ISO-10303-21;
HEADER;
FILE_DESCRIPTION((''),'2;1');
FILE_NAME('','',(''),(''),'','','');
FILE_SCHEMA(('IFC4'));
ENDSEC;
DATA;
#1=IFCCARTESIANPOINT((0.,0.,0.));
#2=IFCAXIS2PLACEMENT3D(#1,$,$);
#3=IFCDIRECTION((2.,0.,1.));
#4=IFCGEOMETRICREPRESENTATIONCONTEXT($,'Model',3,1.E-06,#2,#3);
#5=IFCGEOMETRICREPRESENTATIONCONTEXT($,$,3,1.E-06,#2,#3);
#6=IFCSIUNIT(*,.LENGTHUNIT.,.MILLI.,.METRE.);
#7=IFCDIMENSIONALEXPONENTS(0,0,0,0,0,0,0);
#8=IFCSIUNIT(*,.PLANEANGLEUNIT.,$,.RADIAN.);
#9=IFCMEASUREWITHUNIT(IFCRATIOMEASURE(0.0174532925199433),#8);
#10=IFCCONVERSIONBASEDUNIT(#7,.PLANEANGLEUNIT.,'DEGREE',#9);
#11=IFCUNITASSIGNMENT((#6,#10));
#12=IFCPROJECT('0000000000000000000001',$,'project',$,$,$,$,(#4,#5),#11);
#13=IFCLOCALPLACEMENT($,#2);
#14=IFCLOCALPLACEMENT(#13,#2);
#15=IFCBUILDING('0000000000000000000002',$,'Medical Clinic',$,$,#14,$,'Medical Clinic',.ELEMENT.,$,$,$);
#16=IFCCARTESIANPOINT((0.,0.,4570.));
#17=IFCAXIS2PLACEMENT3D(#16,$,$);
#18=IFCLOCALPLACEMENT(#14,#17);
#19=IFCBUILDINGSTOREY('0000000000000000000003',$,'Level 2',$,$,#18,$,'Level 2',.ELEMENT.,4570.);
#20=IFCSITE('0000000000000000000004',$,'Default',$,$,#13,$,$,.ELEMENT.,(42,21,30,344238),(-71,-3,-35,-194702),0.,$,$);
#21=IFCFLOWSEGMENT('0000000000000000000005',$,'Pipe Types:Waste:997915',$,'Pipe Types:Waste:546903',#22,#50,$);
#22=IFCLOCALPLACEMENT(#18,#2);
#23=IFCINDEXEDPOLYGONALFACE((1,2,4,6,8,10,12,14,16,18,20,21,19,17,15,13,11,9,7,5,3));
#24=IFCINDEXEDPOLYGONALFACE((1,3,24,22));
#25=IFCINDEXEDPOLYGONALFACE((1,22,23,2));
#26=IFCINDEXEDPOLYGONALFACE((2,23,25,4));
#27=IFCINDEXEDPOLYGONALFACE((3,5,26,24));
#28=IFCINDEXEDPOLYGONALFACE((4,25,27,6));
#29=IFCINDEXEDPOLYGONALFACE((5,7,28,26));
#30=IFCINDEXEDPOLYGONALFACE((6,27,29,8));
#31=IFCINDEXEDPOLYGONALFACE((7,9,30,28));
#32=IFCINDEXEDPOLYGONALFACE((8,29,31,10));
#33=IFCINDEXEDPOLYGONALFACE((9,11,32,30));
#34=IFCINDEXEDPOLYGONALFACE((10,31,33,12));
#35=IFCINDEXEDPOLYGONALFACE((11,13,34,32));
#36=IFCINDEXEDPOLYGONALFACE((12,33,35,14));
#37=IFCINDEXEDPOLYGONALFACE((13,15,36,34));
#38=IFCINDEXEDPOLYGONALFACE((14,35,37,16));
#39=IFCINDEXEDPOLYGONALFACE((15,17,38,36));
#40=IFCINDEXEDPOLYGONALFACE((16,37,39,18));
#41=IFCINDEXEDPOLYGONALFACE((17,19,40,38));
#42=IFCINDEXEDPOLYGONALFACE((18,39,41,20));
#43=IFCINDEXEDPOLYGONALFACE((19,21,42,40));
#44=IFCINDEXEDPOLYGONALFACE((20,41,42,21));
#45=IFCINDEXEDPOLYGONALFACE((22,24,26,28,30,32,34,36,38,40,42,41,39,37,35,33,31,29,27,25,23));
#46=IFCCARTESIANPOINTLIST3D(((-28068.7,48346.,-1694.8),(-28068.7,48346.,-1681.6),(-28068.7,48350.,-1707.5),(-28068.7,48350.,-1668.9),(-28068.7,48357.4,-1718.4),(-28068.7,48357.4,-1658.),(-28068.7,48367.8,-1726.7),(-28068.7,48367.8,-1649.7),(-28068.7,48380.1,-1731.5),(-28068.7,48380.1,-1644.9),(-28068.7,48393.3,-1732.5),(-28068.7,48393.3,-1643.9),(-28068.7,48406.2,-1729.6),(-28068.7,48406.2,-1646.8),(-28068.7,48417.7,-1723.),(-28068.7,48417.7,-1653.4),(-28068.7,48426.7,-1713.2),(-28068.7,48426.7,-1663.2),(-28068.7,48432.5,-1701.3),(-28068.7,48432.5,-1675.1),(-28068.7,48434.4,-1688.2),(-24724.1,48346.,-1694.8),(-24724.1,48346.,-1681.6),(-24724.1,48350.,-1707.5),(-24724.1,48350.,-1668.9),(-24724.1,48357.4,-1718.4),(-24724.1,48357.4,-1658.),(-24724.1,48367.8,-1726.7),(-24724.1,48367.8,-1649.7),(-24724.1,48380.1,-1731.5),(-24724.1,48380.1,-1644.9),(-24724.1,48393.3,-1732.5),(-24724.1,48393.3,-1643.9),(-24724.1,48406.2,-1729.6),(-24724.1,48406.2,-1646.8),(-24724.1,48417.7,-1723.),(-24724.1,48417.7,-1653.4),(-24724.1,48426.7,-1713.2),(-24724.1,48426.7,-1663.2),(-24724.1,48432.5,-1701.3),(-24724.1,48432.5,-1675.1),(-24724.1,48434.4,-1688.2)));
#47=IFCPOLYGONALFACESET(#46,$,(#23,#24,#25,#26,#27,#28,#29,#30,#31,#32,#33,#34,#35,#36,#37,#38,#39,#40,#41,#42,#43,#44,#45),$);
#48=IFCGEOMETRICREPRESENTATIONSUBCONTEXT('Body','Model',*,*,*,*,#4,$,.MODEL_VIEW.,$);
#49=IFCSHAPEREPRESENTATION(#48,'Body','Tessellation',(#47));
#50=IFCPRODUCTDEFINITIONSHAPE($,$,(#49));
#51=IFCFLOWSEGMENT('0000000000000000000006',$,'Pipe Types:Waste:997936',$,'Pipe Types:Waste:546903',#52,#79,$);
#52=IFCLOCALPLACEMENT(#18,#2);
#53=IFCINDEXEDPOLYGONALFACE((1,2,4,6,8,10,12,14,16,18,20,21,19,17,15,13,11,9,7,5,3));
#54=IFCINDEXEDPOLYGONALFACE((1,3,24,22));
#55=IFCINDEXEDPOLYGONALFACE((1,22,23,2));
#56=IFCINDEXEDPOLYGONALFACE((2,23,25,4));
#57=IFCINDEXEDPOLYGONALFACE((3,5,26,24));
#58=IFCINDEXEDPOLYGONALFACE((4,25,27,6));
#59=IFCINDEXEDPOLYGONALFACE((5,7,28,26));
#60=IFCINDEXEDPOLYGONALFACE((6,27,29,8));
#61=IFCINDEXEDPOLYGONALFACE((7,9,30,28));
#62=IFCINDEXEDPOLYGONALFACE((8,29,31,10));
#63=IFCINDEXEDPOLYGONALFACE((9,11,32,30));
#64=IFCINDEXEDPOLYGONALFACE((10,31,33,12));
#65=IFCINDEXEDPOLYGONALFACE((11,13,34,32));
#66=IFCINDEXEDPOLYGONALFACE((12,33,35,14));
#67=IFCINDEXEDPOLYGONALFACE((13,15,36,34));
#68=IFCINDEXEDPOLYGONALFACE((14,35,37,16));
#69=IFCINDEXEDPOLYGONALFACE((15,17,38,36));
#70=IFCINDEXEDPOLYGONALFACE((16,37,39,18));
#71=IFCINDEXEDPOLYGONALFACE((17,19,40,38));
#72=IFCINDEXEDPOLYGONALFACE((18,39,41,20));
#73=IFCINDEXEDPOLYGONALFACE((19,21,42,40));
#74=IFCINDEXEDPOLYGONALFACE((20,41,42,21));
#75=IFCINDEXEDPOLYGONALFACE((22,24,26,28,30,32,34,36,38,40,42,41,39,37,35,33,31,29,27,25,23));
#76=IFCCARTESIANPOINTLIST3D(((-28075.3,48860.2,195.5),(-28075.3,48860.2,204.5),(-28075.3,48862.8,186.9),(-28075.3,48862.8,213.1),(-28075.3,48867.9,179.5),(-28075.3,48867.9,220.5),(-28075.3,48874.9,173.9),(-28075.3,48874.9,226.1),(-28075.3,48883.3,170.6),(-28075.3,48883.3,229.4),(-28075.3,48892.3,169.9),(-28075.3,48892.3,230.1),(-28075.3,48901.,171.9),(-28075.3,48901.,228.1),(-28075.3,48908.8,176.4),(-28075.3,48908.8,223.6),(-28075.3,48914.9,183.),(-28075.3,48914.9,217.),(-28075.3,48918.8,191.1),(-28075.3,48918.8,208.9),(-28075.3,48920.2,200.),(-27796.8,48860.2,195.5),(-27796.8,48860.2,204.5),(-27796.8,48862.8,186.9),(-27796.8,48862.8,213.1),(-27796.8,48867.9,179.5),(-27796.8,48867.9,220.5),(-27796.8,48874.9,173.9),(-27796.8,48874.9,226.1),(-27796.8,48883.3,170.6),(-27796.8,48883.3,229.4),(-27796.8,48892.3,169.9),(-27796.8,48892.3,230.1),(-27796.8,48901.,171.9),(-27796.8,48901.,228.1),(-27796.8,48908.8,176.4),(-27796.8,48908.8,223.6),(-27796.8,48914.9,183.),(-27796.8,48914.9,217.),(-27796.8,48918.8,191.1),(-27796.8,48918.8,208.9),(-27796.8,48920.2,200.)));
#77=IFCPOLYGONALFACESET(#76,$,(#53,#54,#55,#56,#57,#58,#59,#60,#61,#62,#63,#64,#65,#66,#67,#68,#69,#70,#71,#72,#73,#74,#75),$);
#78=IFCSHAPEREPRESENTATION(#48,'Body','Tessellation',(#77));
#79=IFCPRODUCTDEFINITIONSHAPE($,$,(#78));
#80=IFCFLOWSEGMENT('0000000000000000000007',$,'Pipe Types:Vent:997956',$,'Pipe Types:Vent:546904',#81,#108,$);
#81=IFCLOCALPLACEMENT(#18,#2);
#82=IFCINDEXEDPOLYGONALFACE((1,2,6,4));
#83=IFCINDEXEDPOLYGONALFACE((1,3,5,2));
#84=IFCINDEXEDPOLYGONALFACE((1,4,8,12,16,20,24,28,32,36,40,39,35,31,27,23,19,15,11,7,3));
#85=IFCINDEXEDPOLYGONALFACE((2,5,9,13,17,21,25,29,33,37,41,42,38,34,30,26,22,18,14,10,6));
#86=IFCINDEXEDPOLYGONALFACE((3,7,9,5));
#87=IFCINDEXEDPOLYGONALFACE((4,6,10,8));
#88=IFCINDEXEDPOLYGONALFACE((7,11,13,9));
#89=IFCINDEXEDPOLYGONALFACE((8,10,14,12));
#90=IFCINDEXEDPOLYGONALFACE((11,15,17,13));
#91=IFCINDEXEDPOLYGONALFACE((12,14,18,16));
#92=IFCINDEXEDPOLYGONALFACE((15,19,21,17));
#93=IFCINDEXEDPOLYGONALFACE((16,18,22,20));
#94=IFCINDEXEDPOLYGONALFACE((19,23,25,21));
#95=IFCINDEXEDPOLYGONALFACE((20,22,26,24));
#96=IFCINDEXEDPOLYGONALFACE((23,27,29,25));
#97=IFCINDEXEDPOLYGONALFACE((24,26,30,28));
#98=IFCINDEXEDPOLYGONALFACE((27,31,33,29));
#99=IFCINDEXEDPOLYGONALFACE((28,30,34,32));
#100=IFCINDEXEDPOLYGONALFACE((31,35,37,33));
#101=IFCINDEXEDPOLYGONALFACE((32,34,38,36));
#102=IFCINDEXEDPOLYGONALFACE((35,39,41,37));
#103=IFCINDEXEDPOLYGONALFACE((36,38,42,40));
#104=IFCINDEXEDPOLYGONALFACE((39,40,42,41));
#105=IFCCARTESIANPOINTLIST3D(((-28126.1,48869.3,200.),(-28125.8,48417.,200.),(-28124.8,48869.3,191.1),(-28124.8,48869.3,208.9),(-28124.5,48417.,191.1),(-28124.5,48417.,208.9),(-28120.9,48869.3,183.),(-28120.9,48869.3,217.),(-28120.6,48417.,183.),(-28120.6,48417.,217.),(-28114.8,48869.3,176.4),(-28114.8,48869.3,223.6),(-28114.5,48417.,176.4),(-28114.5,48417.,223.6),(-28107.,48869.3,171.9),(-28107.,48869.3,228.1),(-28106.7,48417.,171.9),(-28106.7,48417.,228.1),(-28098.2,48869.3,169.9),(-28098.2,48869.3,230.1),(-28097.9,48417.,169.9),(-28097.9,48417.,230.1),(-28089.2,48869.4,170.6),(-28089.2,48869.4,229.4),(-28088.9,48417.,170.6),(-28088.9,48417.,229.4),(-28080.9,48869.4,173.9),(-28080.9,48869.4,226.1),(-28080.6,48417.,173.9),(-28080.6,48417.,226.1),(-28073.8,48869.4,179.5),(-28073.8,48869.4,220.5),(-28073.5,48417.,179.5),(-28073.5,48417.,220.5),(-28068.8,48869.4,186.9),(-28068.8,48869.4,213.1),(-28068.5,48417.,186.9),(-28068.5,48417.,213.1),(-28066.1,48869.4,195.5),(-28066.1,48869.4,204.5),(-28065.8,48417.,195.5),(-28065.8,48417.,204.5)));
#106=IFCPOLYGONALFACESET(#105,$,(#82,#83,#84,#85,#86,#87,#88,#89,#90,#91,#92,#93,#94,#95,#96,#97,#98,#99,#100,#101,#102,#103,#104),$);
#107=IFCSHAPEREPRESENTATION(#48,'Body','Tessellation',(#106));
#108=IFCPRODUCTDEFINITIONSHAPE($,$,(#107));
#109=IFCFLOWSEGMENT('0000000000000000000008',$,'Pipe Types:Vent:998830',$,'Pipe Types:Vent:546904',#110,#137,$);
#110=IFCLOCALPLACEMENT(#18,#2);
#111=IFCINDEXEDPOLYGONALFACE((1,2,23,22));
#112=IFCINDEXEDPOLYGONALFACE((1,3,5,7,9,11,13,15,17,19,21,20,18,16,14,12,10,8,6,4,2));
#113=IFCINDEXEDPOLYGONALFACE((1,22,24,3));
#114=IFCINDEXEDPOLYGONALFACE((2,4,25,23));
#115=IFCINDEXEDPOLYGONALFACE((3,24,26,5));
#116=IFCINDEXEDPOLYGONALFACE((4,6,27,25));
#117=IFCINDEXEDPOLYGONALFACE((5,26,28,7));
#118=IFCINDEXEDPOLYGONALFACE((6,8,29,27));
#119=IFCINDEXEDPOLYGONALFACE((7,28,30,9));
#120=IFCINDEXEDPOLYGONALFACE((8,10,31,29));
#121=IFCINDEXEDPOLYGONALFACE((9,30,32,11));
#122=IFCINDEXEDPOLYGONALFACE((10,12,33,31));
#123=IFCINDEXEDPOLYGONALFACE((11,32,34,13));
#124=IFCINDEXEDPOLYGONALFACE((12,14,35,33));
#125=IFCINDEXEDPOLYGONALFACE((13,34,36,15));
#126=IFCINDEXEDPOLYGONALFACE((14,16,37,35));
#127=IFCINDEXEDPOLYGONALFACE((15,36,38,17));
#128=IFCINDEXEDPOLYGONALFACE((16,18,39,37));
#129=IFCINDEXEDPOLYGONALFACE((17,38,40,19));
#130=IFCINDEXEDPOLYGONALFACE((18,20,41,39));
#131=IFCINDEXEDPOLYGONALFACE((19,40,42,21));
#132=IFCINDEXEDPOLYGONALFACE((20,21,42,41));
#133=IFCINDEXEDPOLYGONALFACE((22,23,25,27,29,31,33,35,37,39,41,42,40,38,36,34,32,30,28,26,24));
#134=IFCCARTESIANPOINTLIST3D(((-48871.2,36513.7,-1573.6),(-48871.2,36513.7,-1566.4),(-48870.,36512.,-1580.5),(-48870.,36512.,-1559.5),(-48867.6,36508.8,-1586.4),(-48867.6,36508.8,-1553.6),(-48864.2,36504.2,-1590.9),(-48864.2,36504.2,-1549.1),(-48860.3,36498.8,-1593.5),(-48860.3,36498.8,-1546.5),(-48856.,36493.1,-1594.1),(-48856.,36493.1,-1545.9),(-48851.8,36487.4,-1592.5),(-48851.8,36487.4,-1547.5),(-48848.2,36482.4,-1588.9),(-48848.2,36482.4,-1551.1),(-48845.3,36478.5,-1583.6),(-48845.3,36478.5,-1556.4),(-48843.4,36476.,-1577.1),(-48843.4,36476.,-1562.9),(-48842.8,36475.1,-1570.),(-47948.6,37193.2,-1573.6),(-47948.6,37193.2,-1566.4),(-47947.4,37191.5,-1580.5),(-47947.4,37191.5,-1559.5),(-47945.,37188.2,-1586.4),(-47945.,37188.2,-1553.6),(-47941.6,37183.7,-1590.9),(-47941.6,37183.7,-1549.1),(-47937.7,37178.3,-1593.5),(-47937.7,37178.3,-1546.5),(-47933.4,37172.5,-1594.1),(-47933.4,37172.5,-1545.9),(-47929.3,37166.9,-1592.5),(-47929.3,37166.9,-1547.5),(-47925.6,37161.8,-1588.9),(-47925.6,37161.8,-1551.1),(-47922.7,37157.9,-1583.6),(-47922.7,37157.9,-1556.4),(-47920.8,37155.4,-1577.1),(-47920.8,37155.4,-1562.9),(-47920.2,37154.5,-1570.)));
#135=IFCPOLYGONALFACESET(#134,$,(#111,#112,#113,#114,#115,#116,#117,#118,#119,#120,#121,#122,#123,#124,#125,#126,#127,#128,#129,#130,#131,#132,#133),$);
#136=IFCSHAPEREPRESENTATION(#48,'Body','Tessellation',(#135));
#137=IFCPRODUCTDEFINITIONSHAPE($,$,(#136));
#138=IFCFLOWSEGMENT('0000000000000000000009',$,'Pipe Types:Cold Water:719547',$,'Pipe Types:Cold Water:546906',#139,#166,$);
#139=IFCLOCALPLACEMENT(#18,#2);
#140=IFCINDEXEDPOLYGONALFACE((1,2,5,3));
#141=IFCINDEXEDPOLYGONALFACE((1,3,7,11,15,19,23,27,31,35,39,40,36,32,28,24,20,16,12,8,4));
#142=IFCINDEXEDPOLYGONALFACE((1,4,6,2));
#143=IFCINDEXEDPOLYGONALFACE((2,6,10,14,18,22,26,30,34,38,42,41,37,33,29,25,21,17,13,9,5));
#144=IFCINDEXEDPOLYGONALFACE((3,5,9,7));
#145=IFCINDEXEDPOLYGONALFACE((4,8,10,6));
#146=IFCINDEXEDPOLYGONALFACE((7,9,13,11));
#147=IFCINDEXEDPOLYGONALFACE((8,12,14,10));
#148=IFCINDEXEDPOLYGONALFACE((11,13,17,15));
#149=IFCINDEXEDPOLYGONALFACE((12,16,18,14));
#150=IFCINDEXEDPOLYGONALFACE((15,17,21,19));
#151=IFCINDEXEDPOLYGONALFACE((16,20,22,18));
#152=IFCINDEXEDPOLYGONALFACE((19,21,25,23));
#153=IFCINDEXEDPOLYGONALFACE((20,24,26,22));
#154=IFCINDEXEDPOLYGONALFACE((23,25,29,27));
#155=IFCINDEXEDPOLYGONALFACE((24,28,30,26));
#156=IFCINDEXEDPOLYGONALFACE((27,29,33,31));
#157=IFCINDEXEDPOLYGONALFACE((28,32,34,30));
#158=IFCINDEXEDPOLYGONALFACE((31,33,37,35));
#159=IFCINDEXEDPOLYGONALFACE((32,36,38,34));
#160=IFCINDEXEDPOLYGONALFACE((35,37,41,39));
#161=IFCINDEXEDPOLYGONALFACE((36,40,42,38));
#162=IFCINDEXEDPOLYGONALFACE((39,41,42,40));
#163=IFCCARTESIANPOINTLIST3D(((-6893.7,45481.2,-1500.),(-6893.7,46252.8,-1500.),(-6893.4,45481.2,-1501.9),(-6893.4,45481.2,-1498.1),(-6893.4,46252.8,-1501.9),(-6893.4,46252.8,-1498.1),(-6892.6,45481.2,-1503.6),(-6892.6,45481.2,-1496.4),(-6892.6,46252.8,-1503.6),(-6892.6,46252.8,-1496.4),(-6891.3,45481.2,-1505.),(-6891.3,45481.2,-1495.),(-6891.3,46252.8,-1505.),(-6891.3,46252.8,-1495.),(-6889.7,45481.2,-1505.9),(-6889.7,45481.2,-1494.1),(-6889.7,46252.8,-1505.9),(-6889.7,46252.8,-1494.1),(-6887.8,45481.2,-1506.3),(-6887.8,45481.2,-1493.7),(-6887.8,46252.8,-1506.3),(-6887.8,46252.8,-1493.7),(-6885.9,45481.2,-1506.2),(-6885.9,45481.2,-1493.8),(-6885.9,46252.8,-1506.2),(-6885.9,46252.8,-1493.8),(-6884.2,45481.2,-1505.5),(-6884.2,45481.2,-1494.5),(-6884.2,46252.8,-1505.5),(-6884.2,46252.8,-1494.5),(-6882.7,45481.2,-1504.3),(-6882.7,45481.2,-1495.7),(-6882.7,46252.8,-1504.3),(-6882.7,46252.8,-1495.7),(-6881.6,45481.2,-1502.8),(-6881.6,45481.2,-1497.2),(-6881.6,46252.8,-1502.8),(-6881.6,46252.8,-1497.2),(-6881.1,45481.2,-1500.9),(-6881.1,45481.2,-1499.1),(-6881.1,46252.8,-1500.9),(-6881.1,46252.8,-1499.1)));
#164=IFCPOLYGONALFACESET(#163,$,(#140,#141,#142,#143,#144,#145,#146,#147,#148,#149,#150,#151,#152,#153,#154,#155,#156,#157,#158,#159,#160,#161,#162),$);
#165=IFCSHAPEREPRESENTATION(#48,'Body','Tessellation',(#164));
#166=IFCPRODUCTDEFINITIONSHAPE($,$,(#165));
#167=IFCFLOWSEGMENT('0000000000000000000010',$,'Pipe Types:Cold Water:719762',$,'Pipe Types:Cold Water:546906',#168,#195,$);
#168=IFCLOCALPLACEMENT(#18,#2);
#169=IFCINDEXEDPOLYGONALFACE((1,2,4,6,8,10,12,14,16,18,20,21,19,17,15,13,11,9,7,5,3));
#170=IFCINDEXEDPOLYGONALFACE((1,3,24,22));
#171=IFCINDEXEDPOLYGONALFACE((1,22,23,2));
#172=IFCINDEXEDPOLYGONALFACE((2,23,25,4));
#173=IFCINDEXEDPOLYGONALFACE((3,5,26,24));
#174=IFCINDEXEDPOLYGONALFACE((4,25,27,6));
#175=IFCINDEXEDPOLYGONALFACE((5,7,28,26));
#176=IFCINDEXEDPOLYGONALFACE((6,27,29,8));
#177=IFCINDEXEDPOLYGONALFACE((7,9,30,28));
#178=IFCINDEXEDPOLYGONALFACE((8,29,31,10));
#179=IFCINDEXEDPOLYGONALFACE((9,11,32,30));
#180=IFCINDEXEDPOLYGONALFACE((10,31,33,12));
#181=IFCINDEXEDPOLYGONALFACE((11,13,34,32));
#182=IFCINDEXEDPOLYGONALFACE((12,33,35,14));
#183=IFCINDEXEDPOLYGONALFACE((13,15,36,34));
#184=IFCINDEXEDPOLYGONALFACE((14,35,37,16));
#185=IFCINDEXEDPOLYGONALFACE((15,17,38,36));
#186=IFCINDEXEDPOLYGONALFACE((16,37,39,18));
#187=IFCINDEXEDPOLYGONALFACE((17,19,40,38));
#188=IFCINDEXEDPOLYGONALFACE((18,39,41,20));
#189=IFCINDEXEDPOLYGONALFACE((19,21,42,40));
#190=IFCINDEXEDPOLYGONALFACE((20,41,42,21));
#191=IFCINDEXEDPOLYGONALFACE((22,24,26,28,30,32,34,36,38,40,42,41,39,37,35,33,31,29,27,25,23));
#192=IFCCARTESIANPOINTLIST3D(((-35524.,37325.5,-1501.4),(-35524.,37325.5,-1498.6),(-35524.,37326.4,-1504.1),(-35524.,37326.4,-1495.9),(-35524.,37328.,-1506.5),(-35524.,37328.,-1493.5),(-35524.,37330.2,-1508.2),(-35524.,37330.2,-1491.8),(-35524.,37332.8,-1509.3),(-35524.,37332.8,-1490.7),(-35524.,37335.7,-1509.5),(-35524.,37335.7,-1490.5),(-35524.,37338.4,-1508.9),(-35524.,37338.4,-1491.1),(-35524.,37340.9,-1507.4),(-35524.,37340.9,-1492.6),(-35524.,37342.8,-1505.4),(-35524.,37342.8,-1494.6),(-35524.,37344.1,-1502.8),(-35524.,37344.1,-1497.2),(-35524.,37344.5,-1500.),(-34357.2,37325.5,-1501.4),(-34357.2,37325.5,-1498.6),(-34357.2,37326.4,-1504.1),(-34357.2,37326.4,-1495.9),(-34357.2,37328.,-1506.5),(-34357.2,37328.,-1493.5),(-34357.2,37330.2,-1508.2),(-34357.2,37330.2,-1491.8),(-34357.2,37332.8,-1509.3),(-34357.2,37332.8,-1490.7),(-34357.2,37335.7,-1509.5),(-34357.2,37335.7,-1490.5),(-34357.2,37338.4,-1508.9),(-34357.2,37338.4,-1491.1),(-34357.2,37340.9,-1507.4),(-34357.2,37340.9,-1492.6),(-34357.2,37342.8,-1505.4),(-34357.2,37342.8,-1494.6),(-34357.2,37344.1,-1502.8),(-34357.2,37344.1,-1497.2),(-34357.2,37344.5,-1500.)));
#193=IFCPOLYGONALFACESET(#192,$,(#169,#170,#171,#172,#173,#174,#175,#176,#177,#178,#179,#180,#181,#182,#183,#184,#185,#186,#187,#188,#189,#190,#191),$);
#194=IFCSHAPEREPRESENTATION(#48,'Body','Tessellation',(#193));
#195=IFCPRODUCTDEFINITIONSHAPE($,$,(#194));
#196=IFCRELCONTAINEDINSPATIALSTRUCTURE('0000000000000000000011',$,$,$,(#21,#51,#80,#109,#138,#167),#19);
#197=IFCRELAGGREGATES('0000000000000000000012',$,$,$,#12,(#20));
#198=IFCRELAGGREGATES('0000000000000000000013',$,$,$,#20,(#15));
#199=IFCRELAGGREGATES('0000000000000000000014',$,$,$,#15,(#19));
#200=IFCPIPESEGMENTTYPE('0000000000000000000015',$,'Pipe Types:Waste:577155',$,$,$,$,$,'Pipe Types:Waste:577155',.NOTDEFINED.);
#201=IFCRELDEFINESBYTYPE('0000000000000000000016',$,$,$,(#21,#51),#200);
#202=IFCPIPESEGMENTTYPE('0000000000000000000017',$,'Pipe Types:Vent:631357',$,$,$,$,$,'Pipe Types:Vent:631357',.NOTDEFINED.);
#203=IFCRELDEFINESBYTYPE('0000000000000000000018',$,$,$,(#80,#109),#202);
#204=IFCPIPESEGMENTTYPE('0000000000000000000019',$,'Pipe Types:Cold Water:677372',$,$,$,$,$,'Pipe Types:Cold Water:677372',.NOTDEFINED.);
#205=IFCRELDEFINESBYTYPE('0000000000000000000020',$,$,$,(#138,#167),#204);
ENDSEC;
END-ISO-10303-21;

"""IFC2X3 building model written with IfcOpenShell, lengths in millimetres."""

from ifc_helpers import new_model, entity, si_unit, converted_unit, direction, frame, frame_2d, origin, origin_2d_with_axis, place, context, subcontext, project, spatial, circle, extrude, type_object, element, save


model = new_model("IFC2X3")

# Units and contexts
model_context = context("Model", 3, precision=1e-06, world=origin(), true_north=direction((2.0, 0.0, 1.0)))
context_of_model = context(None, 3, precision=1e-06, world=origin(), true_north=direction((2.0, 0.0, 1.0)))
body_context = subcontext(model_context, "Body", "Model", "MODEL_VIEW")
ifc_project = project(units=[si_unit("LENGTHUNIT", "METRE", prefix="MILLI"), converted_unit("PLANEANGLEUNIT", "DEGREE", entity("IfcRatioMeasure", 0.0174532925199433), si_unit("PLANEANGLEUNIT", "RADIAN"), dimensions=[0, 0, 0, 0, 0, 0, 0])], contexts=[model_context, context_of_model])

# Site, building, storey
site_placement = place(None, origin())
site = spatial("IfcSite", under=ifc_project, at=site_placement, Name="Default", CompositionType="ELEMENT", RefLatitude=(42, 21, 30, 344238), RefLongitude=(-71, -3, -35, -194702), RefElevation=0.0)
building_placement = place(site_placement, origin())
building = spatial("IfcBuilding", under=site, at=building_placement, Name="Medical Clinic", LongName="Medical Clinic", CompositionType="ELEMENT")
storey_placement = place(building_placement, frame((0.0, 0.0, 4570.0)))
storey = spatial("IfcBuildingStorey", under=building, at=storey_placement, Name="Level 2", LongName="Level 2", CompositionType="ELEMENT", Elevation=4570.0)

# Flow segments
pipe_segment_type_1 = type_object("IfcPipeSegmentType", Name="Pipe Types:Waste:577155", ElementType="Pipe Types:Waste:577155", PredefinedType="NOTDEFINED")
flow_segment_1_placement = place(storey_placement, origin())
element("IfcFlowSegment", 1, at=flow_segment_1_placement, inside=storey, type_object=pipe_segment_type_1, Name="Pipe Types:Waste:997915", ObjectType="Pipe Types:Waste:546903", context=body_context, shape_type="SweptSolid", body=[
    extrude(circle(Radius=44.5, at=frame_2d((0.0, 0.0), x_axis=(1.0, 0.0))), frame((-28068.7, 48390.0, -1688.2), z_axis=(1.0, 0.0, 0.0), x_axis=(0.0, 1.0, 0.0)), (0.0, 0.0, 1.0), 3344.5),
])
flow_segment_2_placement = place(storey_placement, origin())
element("IfcFlowSegment", 2, at=flow_segment_2_placement, inside=storey, type_object=pipe_segment_type_1, Name="Pipe Types:Waste:997936", ObjectType="Pipe Types:Waste:546903", context=body_context, shape_type="SweptSolid", body=[
    extrude(circle(Radius=30.2, at=origin_2d_with_axis()), frame((-28075.3, 48890.0, 200.0), z_axis=(1.0, 0.0, 0.0), x_axis=(0.0, 1.0, 0.0)), (0.0, 0.0, 1.0), 278.6),
])
pipe_segment_type_2 = type_object("IfcPipeSegmentType", Name="Pipe Types:Vent:631357", ElementType="Pipe Types:Vent:631357", PredefinedType="NOTDEFINED")
flow_segment_3_placement = place(storey_placement, origin())
element("IfcFlowSegment", 3, at=flow_segment_3_placement, inside=storey, type_object=pipe_segment_type_2, Name="Pipe Types:Vent:997956", ObjectType="Pipe Types:Vent:546904", context=body_context, shape_type="SweptSolid", body=[
    extrude(circle(Radius=30.2, at=origin_2d_with_axis()), frame((-28096.0, 48869.3, 200.0), z_axis=(0.000648, -1.0, 0.0), x_axis=(-1.0, -0.000648, 0.0)), (0.0, 0.0, 1.0), 452.4),
])
flow_segment_4_placement = place(storey_placement, origin())
element("IfcFlowSegment", 4, at=flow_segment_4_placement, inside=storey, type_object=pipe_segment_type_2, Name="Pipe Types:Vent:998830", ObjectType="Pipe Types:Vent:546904", context=body_context, shape_type="SweptSolid", body=[
    extrude(circle(Radius=24.1, at=frame_2d((0.0, 0.0), x_axis=(1.0, 0.0))), frame((-48857.1, 36494.5, -1570.0), z_axis=(0.805211, 0.592989, 0.0), x_axis=(0.592989, -0.805211, 0.0)), (0.0, 0.0, 1.0), 1145.8),
])
pipe_segment_type_3 = type_object("IfcPipeSegmentType", Name="Pipe Types:Cold Water:677372", ElementType="Pipe Types:Cold Water:677372", PredefinedType="NOTDEFINED")
flow_segment_5_placement = place(storey_placement, origin())
element("IfcFlowSegment", 5, at=flow_segment_5_placement, inside=storey, type_object=pipe_segment_type_3, Name="Pipe Types:Cold Water:719547", ObjectType="Pipe Types:Cold Water:546906", context=body_context, shape_type="SweptSolid", body=[
    extrude(circle(Radius=6.3, at=frame_2d((0.0, 0.0), x_axis=(1.0, 0.0))), frame((-6887.4, 45481.2, -1500.0), z_axis=(0.0, 1.0, 0.0), x_axis=(-1.0, 0.0, 0.0)), (0.0, 0.0, 1.0), 771.6),
])
flow_segment_6_placement = place(storey_placement, origin())
element("IfcFlowSegment", 6, at=flow_segment_6_placement, inside=storey, type_object=pipe_segment_type_3, Name="Pipe Types:Cold Water:719762", ObjectType="Pipe Types:Cold Water:546906", context=body_context, shape_type="SweptSolid", body=[
    extrude(circle(Radius=9.5, at=frame_2d((0.0, 0.0), x_axis=(1.0, 0.0))), frame((-35524.0, 37335.0, -1500.0), z_axis=(1.0, 0.0, 0.0), x_axis=(0.0, 1.0, 0.0)), (0.0, 0.0, 1.0), 1166.7),
])

save(model, "model.ifc")
